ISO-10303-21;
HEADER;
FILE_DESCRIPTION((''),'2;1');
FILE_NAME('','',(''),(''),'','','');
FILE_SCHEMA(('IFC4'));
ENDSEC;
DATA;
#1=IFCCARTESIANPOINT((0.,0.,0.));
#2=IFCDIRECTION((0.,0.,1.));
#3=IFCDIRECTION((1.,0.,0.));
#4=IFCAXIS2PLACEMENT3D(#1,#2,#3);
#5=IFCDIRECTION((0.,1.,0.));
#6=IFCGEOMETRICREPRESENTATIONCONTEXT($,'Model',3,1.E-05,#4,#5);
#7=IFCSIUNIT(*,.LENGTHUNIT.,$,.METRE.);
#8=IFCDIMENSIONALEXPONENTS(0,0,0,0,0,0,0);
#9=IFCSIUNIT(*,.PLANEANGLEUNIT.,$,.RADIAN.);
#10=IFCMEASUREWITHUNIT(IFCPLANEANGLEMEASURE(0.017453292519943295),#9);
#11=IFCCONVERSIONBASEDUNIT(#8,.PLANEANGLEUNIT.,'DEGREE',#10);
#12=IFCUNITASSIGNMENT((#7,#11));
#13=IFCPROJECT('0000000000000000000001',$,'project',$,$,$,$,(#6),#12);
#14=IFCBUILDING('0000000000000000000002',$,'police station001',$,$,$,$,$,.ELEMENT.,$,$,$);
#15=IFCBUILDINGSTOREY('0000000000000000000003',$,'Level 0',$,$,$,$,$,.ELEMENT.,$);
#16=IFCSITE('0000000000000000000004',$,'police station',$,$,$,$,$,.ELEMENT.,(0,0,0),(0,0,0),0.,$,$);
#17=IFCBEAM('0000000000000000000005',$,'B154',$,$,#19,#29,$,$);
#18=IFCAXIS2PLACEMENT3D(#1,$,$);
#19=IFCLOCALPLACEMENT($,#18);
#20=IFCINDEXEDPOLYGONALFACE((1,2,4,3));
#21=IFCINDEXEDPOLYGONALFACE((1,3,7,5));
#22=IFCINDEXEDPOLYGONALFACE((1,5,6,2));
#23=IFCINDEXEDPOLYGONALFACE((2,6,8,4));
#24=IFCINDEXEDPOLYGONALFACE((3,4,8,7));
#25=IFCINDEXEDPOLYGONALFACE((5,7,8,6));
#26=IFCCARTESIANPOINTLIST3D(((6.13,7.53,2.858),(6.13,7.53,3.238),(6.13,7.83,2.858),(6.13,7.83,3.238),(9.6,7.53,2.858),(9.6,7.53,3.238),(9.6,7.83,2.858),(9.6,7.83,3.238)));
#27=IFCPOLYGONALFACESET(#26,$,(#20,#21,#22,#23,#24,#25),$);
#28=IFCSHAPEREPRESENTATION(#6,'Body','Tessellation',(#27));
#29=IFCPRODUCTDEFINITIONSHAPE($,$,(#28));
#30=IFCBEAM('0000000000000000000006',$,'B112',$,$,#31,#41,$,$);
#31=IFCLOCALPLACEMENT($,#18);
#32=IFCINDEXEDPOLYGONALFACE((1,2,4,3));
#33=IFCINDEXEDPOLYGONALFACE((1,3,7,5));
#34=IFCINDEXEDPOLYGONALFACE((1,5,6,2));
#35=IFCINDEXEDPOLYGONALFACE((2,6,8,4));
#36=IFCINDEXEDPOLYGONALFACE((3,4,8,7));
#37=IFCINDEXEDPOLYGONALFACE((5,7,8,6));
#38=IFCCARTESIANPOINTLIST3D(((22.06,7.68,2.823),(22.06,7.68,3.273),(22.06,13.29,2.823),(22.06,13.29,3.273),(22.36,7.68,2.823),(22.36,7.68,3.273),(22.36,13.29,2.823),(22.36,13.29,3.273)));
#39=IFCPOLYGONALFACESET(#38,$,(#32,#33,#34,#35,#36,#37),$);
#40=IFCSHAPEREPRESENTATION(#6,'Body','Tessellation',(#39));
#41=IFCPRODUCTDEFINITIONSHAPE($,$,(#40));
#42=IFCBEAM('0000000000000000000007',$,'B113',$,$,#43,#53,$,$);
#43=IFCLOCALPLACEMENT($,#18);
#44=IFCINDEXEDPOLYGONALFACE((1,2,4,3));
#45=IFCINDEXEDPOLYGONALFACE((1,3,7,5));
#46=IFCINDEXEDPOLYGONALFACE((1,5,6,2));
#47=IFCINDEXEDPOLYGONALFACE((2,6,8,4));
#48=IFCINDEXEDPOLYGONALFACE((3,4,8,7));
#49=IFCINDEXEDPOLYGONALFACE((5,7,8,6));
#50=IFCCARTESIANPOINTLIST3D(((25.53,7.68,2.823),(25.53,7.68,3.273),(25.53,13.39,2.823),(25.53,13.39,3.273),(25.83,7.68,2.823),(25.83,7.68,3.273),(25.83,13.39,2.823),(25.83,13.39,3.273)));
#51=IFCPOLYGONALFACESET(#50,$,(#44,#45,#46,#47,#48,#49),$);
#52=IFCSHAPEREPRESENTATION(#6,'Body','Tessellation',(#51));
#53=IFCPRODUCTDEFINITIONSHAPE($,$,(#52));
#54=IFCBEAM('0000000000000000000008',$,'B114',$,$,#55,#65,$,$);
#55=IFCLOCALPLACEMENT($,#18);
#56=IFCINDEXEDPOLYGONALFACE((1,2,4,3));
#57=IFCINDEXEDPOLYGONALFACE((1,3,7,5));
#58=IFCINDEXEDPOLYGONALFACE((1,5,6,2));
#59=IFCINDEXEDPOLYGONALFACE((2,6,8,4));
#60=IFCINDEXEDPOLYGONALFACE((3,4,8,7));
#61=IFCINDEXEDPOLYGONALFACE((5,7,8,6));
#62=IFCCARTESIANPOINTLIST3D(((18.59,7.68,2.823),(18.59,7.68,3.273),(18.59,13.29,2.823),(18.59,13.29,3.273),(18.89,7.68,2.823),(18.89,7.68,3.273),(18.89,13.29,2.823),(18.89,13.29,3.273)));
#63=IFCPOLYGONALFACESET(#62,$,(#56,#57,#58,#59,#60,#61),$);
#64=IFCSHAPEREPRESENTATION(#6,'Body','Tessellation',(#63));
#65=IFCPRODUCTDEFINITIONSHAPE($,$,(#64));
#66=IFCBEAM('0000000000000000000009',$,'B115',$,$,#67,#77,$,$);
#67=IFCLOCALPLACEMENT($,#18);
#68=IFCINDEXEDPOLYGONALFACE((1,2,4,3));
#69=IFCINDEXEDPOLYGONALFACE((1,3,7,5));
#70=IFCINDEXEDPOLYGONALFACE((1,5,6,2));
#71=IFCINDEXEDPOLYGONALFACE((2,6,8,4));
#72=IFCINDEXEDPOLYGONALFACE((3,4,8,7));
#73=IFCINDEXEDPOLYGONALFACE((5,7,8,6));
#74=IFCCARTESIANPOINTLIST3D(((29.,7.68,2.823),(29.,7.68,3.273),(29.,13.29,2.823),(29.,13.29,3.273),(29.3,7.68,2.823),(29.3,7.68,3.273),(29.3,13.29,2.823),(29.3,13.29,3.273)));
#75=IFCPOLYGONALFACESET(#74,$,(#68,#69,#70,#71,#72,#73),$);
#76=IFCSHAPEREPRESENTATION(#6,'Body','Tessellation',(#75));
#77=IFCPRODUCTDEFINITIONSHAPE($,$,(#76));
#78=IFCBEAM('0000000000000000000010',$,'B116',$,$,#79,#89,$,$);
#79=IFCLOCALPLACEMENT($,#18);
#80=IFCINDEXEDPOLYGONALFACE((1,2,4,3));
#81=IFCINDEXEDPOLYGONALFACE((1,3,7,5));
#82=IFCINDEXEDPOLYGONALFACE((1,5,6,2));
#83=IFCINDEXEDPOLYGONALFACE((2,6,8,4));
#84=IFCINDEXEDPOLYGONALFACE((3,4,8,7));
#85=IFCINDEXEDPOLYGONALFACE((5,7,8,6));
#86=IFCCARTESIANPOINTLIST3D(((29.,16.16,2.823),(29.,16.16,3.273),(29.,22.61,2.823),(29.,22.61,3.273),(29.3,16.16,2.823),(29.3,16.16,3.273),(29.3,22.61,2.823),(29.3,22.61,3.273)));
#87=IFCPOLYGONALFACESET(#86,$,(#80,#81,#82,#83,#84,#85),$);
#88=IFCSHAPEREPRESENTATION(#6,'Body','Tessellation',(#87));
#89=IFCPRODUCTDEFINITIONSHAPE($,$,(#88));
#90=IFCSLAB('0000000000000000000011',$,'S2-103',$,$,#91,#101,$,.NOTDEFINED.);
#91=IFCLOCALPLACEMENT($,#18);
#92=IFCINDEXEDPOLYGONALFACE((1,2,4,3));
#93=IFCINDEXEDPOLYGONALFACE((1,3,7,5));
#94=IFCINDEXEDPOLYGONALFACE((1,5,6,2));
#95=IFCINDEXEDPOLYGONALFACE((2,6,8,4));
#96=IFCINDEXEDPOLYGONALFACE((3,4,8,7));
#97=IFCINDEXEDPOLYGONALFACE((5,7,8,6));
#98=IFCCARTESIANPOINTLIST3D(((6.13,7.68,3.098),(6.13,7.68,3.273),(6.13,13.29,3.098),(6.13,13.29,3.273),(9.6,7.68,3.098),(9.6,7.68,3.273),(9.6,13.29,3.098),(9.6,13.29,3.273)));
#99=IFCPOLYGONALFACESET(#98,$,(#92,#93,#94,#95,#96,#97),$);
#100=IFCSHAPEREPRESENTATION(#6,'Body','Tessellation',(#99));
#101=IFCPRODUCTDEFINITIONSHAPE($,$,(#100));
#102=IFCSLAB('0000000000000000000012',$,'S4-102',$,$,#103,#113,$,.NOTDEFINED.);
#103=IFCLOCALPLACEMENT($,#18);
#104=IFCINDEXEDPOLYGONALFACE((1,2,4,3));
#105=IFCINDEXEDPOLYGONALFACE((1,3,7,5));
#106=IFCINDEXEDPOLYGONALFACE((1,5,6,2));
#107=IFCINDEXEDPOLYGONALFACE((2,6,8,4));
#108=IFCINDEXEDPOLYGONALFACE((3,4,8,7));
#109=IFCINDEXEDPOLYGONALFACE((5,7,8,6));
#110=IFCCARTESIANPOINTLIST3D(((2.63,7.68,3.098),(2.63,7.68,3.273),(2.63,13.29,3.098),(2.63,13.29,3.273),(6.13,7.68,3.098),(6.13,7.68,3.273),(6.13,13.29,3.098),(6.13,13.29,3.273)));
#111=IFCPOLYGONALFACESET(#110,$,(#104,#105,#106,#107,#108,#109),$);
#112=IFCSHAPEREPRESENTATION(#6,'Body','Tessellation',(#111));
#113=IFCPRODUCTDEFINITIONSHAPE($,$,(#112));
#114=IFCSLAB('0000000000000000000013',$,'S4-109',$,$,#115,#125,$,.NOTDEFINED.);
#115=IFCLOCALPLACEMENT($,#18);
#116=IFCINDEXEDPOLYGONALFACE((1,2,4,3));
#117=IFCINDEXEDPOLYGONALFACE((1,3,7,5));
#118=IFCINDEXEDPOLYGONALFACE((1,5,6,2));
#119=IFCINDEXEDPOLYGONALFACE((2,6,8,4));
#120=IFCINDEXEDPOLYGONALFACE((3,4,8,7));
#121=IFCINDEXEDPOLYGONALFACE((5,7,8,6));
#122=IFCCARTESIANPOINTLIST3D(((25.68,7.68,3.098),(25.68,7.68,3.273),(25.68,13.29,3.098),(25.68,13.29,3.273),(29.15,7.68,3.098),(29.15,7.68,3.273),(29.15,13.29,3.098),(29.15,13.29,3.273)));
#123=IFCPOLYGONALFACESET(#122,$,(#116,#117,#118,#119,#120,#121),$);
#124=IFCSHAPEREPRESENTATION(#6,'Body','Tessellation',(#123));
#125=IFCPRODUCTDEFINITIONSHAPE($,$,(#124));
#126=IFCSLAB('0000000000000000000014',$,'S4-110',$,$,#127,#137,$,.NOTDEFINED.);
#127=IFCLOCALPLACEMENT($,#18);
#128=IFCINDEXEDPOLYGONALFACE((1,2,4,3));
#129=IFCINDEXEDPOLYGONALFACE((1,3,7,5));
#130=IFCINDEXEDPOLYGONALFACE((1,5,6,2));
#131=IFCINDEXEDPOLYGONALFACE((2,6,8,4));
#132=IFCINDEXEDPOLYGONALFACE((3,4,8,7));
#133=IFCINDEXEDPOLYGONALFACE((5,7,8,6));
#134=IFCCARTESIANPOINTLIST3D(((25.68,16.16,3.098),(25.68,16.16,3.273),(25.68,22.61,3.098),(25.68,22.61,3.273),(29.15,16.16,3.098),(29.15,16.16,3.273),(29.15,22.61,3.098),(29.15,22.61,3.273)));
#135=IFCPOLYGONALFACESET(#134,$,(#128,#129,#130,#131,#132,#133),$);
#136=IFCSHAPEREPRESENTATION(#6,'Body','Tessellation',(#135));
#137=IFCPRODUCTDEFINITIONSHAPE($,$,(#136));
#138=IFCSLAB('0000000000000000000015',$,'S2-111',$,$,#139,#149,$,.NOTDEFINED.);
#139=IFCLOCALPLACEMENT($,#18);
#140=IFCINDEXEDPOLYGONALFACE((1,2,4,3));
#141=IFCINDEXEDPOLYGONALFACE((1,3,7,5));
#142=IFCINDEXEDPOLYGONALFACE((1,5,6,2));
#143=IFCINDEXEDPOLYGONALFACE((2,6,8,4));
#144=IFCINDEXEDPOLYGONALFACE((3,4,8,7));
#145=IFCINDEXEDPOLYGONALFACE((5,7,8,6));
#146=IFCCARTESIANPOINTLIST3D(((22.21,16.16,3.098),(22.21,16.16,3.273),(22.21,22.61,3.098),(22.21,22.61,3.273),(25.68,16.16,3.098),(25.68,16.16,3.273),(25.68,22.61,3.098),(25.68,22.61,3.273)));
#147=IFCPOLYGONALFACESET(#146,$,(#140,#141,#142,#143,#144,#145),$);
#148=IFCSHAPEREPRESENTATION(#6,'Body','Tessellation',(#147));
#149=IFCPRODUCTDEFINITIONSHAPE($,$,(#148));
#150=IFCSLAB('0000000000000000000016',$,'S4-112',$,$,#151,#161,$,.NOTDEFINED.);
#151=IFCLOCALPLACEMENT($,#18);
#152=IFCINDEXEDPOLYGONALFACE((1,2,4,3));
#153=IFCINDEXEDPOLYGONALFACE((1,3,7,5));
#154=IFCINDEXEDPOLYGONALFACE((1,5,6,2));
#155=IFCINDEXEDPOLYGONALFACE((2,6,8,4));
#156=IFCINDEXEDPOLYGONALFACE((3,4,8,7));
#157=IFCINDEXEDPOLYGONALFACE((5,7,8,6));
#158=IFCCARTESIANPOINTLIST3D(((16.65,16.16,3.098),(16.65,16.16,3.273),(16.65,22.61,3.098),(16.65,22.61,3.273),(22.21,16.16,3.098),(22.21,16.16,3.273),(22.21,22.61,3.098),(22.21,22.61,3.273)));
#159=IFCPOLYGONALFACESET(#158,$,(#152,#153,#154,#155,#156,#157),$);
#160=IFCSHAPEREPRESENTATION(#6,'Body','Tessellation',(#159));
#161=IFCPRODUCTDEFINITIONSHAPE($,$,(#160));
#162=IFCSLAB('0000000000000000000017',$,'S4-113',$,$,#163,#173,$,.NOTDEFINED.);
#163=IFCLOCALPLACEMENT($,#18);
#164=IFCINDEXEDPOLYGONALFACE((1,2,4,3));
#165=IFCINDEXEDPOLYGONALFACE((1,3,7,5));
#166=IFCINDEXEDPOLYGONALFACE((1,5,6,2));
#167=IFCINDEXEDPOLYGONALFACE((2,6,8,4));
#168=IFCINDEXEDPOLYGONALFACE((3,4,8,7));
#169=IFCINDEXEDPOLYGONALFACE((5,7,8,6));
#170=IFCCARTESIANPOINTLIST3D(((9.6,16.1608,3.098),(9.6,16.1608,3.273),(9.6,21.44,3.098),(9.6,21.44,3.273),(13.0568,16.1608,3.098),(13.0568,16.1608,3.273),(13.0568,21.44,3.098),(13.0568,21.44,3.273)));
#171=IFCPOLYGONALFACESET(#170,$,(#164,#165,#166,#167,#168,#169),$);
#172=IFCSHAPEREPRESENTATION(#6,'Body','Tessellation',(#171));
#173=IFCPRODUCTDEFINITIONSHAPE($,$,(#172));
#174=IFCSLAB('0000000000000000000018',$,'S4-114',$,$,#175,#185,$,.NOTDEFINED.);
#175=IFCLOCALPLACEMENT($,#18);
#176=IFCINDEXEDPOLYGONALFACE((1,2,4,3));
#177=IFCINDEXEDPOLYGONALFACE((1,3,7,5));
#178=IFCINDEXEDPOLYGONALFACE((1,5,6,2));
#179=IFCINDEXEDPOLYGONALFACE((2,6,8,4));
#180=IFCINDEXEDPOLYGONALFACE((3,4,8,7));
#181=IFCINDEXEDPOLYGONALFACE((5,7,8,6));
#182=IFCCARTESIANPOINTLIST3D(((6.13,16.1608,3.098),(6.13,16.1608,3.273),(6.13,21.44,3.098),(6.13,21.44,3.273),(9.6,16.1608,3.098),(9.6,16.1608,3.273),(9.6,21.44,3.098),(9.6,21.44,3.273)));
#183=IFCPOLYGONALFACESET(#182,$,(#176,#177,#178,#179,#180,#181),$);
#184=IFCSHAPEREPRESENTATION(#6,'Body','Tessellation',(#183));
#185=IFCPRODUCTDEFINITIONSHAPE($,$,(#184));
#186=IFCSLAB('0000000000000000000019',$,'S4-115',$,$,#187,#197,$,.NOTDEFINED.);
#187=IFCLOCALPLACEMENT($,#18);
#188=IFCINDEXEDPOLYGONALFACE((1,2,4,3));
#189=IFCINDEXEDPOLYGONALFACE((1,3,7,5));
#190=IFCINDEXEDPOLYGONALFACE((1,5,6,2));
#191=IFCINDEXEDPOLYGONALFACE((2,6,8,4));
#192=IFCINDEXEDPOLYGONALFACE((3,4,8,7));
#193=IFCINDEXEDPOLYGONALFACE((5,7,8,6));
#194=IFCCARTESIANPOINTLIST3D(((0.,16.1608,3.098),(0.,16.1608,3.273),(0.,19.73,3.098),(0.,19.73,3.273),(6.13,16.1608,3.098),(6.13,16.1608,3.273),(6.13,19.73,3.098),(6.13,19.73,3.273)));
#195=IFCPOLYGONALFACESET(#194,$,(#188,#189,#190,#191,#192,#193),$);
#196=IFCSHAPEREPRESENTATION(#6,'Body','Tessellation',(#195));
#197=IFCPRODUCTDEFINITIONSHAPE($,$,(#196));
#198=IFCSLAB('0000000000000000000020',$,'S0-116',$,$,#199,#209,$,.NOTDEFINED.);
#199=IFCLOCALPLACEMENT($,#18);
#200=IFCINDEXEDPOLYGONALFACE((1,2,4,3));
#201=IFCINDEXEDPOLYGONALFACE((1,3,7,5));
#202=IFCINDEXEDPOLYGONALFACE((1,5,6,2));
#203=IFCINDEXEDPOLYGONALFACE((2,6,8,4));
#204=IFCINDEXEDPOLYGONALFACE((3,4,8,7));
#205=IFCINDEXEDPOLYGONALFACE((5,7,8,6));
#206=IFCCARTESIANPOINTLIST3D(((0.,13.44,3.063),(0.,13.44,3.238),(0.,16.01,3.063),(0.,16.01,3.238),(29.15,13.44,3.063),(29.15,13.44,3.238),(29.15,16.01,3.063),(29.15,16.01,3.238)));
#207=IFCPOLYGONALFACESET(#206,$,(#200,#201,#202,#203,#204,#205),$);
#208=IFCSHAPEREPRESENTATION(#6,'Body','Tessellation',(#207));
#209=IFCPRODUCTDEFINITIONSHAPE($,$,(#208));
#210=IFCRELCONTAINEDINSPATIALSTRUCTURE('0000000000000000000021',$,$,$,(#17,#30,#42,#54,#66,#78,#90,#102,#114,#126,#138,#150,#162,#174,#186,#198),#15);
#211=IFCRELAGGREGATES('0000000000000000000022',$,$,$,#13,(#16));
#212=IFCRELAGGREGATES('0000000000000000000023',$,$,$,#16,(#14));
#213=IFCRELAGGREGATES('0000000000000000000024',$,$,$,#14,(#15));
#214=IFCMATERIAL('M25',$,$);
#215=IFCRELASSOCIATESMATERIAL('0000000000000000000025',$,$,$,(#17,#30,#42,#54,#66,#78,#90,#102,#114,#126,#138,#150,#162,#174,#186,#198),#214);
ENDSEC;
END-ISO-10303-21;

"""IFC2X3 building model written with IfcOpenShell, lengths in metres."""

from ifc_helpers import new_model, entity, si_unit, converted_unit, direction, frame, frame_2d, origin_with_axes, place, context, project, spatial, rectangle, extrude, material, element, save


model = new_model("IFC2X3")

# Units and contexts
model_context = context("Model", 3, precision=1e-05, world=origin_with_axes(), true_north=direction((0.0, 1.0, 0.0)))
ifc_project = project(units=[si_unit("LENGTHUNIT", "METRE"), converted_unit("PLANEANGLEUNIT", "DEGREE", entity("IfcPlaneAngleMeasure", 0.017453292519943295), si_unit("PLANEANGLEUNIT", "RADIAN"), dimensions=[0, 0, 0, 0, 0, 0, 0])], contexts=[model_context])

# Site, building, storey
site = spatial("IfcSite", under=ifc_project, Name="police station", CompositionType="ELEMENT", RefLatitude=(0, 0, 0), RefLongitude=(0, 0, 0), RefElevation=0.0)
building = spatial("IfcBuilding", under=site, Name="police station001", CompositionType="ELEMENT")
storey = spatial("IfcBuildingStorey", under=building, Name="Level 0", CompositionType="ELEMENT")

# Shared definitions
ifc_material = material(Name="M25")
placement = place(None, origin_with_axes())

# Beams
element("IfcBeam", 1, at=placement, inside=storey, material=ifc_material, Name="B154", context=model_context, shape_type="SweptSolid", body=[
    extrude(rectangle(XDim=0.3, YDim=0.38, at=frame_2d((0.0, 0.0), x_axis=(0.0, 1.0, 0.0))), frame((6.13, 7.68, 3.048), z_axis=(1.0, 0.0, 0.0), x_axis=(0.0, 0.0, -1.0)), (0.0, 0.0, 1.0), 3.47),
])
element("IfcBeam", 2, at=placement, inside=storey, material=ifc_material, Name="B112", context=model_context, shape_type="SweptSolid", body=[
    extrude(rectangle(XDim=0.3, YDim=0.45, at=frame_2d((0.0, 0.0), x_axis=(0.0, 1.0, 0.0))), frame((22.21, 7.68, 3.048), z_axis=(0.0, 1.0, 0.0), x_axis=(0.0, 0.0, -1.0)), (0.0, 0.0, 1.0), 5.61),
])
element("IfcBeam", 3, at=placement, inside=storey, material=ifc_material, Name="B113", context=model_context, shape_type="SweptSolid", body=[
    extrude(rectangle(XDim=0.3, YDim=0.45, at=frame_2d((0.0, 0.0), x_axis=(0.0, 1.0, 0.0))), frame((25.68, 7.68, 3.048), z_axis=(0.0, 1.0, 0.0), x_axis=(0.0, 0.0, -1.0)), (0.0, 0.0, 1.0), 5.71),
])
element("IfcBeam", 4, at=placement, inside=storey, material=ifc_material, Name="B114", context=model_context, shape_type="SweptSolid", body=[
    extrude(rectangle(XDim=0.3, YDim=0.45, at=frame_2d((0.0, 0.0), x_axis=(0.0, 1.0, 0.0))), frame((18.74, 13.29, 3.048), z_axis=(0.0, -1.0, 0.0), x_axis=(0.0, 0.0, -1.0)), (0.0, 0.0, 1.0), 5.61),
])
element("IfcBeam", 5, at=placement, inside=storey, material=ifc_material, Name="B115", context=model_context, shape_type="SweptSolid", body=[
    extrude(rectangle(XDim=0.3, YDim=0.45, at=frame_2d((0.0, 0.0), x_axis=(0.0, 1.0, 0.0))), frame((29.15, 13.29, 3.048), z_axis=(0.0, -1.0, 0.0), x_axis=(0.0, 0.0, -1.0)), (0.0, 0.0, 1.0), 5.61),
])
element("IfcBeam", 6, at=placement, inside=storey, material=ifc_material, Name="B116", context=model_context, shape_type="SweptSolid", body=[
    extrude(rectangle(XDim=0.3, YDim=0.45, at=frame_2d((0.0, 0.0), x_axis=(0.0, 1.0, 0.0))), frame((29.15, 16.16, 3.048), z_axis=(0.0, 1.0, 0.0), x_axis=(0.0, 0.0, -1.0)), (0.0, 0.0, 1.0), 6.45),
])

# Slabs
element("IfcSlab", 7, at=placement, inside=storey, material=ifc_material, Name="S2-103", PredefinedType="NOTDEFINED", context=model_context, shape_type="SweptSolid", body=[
    extrude(rectangle(XDim=3.47, YDim=5.61, at=frame_2d((0.0, 0.0), x_axis=(1.0, 0.0, 0.0))), frame((7.865, 10.485, 3.098), z_axis=(0.0, 0.0, 1.0), x_axis=(1.0, 0.0, 0.0)), (0.0, 0.0, 1.0), 0.175),
])
element("IfcSlab", 8, at=placement, inside=storey, material=ifc_material, Name="S4-102", PredefinedType="NOTDEFINED", context=model_context, shape_type="SweptSolid", body=[
    extrude(rectangle(XDim=3.5, YDim=5.61, at=frame_2d((0.0, 0.0), x_axis=(1.0, 0.0, 0.0))), frame((4.38, 10.485, 3.098), z_axis=(0.0, 0.0, 1.0), x_axis=(1.0, 0.0, 0.0)), (0.0, 0.0, 1.0), 0.175),
])
element("IfcSlab", 9, at=placement, inside=storey, material=ifc_material, Name="S4-109", PredefinedType="NOTDEFINED", context=model_context, shape_type="SweptSolid", body=[
    extrude(rectangle(XDim=3.47, YDim=5.61, at=frame_2d((0.0, 0.0), x_axis=(1.0, 0.0, 0.0))), frame((27.415, 10.485, 3.098), z_axis=(0.0, 0.0, 1.0), x_axis=(1.0, 0.0, 0.0)), (0.0, 0.0, 1.0), 0.175),
])
element("IfcSlab", 10, at=placement, inside=storey, material=ifc_material, Name="S4-110", PredefinedType="NOTDEFINED", context=model_context, shape_type="SweptSolid", body=[
    extrude(rectangle(XDim=3.47, YDim=6.45, at=frame_2d((0.0, 0.0), x_axis=(1.0, 0.0, 0.0))), frame((27.415, 19.385, 3.098), z_axis=(0.0, 0.0, 1.0), x_axis=(1.0, 0.0, 0.0)), (0.0, 0.0, 1.0), 0.175),
])
element("IfcSlab", 11, at=placement, inside=storey, material=ifc_material, Name="S2-111", PredefinedType="NOTDEFINED", context=model_context, shape_type="SweptSolid", body=[
    extrude(rectangle(XDim=3.47, YDim=6.45, at=frame_2d((0.0, 0.0), x_axis=(1.0, 0.0, 0.0))), frame((23.945, 19.385, 3.098), z_axis=(0.0, 0.0, 1.0), x_axis=(1.0, 0.0, 0.0)), (0.0, 0.0, 1.0), 0.175),
])
element("IfcSlab", 12, at=placement, inside=storey, material=ifc_material, Name="S4-112", PredefinedType="NOTDEFINED", context=model_context, shape_type="SweptSolid", body=[
    extrude(rectangle(XDim=5.56, YDim=6.45, at=frame_2d((0.0, 0.0), x_axis=(1.0, 0.0, 0.0))), frame((19.43, 19.385, 3.098), z_axis=(0.0, 0.0, 1.0), x_axis=(1.0, 0.0, 0.0)), (0.0, 0.0, 1.0), 0.175),
])
element("IfcSlab", 13, at=placement, inside=storey, material=ifc_material, Name="S4-113", PredefinedType="NOTDEFINED", context=model_context, shape_type="SweptSolid", body=[
    extrude(rectangle(XDim=3.4568, YDim=5.2792, at=frame_2d((0.0, 0.0), x_axis=(1.0, 0.0, 0.0))), frame((11.3284, 18.8004, 3.098), z_axis=(0.0, 0.0, 1.0), x_axis=(1.0, 0.0, 0.0)), (0.0, 0.0, 1.0), 0.175),
])
element("IfcSlab", 14, at=placement, inside=storey, material=ifc_material, Name="S4-114", PredefinedType="NOTDEFINED", context=model_context, shape_type="SweptSolid", body=[
    extrude(rectangle(XDim=3.47, YDim=5.2792, at=frame_2d((0.0, 0.0), x_axis=(1.0, 0.0, 0.0))), frame((7.865, 18.8004, 3.098), z_axis=(0.0, 0.0, 1.0), x_axis=(1.0, 0.0, 0.0)), (0.0, 0.0, 1.0), 0.175),
])
element("IfcSlab", 15, at=placement, inside=storey, material=ifc_material, Name="S4-115", PredefinedType="NOTDEFINED", context=model_context, shape_type="SweptSolid", body=[
    extrude(rectangle(XDim=6.13, YDim=3.5692, at=frame_2d((0.0, 0.0), x_axis=(1.0, 0.0, 0.0))), frame((3.065, 17.9454, 3.098), z_axis=(0.0, 0.0, 1.0), x_axis=(1.0, 0.0, 0.0)), (0.0, 0.0, 1.0), 0.175),
])
element("IfcSlab", 16, at=placement, inside=storey, material=ifc_material, Name="S0-116", PredefinedType="NOTDEFINED", context=model_context, shape_type="SweptSolid", body=[
    extrude(rectangle(XDim=29.15, YDim=2.57, at=frame_2d((0.0, 0.0), x_axis=(1.0, 0.0, 0.0))), frame((14.575, 14.725, 3.063), z_axis=(0.0, 0.0, 1.0), x_axis=(1.0, 0.0, 0.0)), (0.0, 0.0, 1.0), 0.175),
])

save(model, "model.ifc")
